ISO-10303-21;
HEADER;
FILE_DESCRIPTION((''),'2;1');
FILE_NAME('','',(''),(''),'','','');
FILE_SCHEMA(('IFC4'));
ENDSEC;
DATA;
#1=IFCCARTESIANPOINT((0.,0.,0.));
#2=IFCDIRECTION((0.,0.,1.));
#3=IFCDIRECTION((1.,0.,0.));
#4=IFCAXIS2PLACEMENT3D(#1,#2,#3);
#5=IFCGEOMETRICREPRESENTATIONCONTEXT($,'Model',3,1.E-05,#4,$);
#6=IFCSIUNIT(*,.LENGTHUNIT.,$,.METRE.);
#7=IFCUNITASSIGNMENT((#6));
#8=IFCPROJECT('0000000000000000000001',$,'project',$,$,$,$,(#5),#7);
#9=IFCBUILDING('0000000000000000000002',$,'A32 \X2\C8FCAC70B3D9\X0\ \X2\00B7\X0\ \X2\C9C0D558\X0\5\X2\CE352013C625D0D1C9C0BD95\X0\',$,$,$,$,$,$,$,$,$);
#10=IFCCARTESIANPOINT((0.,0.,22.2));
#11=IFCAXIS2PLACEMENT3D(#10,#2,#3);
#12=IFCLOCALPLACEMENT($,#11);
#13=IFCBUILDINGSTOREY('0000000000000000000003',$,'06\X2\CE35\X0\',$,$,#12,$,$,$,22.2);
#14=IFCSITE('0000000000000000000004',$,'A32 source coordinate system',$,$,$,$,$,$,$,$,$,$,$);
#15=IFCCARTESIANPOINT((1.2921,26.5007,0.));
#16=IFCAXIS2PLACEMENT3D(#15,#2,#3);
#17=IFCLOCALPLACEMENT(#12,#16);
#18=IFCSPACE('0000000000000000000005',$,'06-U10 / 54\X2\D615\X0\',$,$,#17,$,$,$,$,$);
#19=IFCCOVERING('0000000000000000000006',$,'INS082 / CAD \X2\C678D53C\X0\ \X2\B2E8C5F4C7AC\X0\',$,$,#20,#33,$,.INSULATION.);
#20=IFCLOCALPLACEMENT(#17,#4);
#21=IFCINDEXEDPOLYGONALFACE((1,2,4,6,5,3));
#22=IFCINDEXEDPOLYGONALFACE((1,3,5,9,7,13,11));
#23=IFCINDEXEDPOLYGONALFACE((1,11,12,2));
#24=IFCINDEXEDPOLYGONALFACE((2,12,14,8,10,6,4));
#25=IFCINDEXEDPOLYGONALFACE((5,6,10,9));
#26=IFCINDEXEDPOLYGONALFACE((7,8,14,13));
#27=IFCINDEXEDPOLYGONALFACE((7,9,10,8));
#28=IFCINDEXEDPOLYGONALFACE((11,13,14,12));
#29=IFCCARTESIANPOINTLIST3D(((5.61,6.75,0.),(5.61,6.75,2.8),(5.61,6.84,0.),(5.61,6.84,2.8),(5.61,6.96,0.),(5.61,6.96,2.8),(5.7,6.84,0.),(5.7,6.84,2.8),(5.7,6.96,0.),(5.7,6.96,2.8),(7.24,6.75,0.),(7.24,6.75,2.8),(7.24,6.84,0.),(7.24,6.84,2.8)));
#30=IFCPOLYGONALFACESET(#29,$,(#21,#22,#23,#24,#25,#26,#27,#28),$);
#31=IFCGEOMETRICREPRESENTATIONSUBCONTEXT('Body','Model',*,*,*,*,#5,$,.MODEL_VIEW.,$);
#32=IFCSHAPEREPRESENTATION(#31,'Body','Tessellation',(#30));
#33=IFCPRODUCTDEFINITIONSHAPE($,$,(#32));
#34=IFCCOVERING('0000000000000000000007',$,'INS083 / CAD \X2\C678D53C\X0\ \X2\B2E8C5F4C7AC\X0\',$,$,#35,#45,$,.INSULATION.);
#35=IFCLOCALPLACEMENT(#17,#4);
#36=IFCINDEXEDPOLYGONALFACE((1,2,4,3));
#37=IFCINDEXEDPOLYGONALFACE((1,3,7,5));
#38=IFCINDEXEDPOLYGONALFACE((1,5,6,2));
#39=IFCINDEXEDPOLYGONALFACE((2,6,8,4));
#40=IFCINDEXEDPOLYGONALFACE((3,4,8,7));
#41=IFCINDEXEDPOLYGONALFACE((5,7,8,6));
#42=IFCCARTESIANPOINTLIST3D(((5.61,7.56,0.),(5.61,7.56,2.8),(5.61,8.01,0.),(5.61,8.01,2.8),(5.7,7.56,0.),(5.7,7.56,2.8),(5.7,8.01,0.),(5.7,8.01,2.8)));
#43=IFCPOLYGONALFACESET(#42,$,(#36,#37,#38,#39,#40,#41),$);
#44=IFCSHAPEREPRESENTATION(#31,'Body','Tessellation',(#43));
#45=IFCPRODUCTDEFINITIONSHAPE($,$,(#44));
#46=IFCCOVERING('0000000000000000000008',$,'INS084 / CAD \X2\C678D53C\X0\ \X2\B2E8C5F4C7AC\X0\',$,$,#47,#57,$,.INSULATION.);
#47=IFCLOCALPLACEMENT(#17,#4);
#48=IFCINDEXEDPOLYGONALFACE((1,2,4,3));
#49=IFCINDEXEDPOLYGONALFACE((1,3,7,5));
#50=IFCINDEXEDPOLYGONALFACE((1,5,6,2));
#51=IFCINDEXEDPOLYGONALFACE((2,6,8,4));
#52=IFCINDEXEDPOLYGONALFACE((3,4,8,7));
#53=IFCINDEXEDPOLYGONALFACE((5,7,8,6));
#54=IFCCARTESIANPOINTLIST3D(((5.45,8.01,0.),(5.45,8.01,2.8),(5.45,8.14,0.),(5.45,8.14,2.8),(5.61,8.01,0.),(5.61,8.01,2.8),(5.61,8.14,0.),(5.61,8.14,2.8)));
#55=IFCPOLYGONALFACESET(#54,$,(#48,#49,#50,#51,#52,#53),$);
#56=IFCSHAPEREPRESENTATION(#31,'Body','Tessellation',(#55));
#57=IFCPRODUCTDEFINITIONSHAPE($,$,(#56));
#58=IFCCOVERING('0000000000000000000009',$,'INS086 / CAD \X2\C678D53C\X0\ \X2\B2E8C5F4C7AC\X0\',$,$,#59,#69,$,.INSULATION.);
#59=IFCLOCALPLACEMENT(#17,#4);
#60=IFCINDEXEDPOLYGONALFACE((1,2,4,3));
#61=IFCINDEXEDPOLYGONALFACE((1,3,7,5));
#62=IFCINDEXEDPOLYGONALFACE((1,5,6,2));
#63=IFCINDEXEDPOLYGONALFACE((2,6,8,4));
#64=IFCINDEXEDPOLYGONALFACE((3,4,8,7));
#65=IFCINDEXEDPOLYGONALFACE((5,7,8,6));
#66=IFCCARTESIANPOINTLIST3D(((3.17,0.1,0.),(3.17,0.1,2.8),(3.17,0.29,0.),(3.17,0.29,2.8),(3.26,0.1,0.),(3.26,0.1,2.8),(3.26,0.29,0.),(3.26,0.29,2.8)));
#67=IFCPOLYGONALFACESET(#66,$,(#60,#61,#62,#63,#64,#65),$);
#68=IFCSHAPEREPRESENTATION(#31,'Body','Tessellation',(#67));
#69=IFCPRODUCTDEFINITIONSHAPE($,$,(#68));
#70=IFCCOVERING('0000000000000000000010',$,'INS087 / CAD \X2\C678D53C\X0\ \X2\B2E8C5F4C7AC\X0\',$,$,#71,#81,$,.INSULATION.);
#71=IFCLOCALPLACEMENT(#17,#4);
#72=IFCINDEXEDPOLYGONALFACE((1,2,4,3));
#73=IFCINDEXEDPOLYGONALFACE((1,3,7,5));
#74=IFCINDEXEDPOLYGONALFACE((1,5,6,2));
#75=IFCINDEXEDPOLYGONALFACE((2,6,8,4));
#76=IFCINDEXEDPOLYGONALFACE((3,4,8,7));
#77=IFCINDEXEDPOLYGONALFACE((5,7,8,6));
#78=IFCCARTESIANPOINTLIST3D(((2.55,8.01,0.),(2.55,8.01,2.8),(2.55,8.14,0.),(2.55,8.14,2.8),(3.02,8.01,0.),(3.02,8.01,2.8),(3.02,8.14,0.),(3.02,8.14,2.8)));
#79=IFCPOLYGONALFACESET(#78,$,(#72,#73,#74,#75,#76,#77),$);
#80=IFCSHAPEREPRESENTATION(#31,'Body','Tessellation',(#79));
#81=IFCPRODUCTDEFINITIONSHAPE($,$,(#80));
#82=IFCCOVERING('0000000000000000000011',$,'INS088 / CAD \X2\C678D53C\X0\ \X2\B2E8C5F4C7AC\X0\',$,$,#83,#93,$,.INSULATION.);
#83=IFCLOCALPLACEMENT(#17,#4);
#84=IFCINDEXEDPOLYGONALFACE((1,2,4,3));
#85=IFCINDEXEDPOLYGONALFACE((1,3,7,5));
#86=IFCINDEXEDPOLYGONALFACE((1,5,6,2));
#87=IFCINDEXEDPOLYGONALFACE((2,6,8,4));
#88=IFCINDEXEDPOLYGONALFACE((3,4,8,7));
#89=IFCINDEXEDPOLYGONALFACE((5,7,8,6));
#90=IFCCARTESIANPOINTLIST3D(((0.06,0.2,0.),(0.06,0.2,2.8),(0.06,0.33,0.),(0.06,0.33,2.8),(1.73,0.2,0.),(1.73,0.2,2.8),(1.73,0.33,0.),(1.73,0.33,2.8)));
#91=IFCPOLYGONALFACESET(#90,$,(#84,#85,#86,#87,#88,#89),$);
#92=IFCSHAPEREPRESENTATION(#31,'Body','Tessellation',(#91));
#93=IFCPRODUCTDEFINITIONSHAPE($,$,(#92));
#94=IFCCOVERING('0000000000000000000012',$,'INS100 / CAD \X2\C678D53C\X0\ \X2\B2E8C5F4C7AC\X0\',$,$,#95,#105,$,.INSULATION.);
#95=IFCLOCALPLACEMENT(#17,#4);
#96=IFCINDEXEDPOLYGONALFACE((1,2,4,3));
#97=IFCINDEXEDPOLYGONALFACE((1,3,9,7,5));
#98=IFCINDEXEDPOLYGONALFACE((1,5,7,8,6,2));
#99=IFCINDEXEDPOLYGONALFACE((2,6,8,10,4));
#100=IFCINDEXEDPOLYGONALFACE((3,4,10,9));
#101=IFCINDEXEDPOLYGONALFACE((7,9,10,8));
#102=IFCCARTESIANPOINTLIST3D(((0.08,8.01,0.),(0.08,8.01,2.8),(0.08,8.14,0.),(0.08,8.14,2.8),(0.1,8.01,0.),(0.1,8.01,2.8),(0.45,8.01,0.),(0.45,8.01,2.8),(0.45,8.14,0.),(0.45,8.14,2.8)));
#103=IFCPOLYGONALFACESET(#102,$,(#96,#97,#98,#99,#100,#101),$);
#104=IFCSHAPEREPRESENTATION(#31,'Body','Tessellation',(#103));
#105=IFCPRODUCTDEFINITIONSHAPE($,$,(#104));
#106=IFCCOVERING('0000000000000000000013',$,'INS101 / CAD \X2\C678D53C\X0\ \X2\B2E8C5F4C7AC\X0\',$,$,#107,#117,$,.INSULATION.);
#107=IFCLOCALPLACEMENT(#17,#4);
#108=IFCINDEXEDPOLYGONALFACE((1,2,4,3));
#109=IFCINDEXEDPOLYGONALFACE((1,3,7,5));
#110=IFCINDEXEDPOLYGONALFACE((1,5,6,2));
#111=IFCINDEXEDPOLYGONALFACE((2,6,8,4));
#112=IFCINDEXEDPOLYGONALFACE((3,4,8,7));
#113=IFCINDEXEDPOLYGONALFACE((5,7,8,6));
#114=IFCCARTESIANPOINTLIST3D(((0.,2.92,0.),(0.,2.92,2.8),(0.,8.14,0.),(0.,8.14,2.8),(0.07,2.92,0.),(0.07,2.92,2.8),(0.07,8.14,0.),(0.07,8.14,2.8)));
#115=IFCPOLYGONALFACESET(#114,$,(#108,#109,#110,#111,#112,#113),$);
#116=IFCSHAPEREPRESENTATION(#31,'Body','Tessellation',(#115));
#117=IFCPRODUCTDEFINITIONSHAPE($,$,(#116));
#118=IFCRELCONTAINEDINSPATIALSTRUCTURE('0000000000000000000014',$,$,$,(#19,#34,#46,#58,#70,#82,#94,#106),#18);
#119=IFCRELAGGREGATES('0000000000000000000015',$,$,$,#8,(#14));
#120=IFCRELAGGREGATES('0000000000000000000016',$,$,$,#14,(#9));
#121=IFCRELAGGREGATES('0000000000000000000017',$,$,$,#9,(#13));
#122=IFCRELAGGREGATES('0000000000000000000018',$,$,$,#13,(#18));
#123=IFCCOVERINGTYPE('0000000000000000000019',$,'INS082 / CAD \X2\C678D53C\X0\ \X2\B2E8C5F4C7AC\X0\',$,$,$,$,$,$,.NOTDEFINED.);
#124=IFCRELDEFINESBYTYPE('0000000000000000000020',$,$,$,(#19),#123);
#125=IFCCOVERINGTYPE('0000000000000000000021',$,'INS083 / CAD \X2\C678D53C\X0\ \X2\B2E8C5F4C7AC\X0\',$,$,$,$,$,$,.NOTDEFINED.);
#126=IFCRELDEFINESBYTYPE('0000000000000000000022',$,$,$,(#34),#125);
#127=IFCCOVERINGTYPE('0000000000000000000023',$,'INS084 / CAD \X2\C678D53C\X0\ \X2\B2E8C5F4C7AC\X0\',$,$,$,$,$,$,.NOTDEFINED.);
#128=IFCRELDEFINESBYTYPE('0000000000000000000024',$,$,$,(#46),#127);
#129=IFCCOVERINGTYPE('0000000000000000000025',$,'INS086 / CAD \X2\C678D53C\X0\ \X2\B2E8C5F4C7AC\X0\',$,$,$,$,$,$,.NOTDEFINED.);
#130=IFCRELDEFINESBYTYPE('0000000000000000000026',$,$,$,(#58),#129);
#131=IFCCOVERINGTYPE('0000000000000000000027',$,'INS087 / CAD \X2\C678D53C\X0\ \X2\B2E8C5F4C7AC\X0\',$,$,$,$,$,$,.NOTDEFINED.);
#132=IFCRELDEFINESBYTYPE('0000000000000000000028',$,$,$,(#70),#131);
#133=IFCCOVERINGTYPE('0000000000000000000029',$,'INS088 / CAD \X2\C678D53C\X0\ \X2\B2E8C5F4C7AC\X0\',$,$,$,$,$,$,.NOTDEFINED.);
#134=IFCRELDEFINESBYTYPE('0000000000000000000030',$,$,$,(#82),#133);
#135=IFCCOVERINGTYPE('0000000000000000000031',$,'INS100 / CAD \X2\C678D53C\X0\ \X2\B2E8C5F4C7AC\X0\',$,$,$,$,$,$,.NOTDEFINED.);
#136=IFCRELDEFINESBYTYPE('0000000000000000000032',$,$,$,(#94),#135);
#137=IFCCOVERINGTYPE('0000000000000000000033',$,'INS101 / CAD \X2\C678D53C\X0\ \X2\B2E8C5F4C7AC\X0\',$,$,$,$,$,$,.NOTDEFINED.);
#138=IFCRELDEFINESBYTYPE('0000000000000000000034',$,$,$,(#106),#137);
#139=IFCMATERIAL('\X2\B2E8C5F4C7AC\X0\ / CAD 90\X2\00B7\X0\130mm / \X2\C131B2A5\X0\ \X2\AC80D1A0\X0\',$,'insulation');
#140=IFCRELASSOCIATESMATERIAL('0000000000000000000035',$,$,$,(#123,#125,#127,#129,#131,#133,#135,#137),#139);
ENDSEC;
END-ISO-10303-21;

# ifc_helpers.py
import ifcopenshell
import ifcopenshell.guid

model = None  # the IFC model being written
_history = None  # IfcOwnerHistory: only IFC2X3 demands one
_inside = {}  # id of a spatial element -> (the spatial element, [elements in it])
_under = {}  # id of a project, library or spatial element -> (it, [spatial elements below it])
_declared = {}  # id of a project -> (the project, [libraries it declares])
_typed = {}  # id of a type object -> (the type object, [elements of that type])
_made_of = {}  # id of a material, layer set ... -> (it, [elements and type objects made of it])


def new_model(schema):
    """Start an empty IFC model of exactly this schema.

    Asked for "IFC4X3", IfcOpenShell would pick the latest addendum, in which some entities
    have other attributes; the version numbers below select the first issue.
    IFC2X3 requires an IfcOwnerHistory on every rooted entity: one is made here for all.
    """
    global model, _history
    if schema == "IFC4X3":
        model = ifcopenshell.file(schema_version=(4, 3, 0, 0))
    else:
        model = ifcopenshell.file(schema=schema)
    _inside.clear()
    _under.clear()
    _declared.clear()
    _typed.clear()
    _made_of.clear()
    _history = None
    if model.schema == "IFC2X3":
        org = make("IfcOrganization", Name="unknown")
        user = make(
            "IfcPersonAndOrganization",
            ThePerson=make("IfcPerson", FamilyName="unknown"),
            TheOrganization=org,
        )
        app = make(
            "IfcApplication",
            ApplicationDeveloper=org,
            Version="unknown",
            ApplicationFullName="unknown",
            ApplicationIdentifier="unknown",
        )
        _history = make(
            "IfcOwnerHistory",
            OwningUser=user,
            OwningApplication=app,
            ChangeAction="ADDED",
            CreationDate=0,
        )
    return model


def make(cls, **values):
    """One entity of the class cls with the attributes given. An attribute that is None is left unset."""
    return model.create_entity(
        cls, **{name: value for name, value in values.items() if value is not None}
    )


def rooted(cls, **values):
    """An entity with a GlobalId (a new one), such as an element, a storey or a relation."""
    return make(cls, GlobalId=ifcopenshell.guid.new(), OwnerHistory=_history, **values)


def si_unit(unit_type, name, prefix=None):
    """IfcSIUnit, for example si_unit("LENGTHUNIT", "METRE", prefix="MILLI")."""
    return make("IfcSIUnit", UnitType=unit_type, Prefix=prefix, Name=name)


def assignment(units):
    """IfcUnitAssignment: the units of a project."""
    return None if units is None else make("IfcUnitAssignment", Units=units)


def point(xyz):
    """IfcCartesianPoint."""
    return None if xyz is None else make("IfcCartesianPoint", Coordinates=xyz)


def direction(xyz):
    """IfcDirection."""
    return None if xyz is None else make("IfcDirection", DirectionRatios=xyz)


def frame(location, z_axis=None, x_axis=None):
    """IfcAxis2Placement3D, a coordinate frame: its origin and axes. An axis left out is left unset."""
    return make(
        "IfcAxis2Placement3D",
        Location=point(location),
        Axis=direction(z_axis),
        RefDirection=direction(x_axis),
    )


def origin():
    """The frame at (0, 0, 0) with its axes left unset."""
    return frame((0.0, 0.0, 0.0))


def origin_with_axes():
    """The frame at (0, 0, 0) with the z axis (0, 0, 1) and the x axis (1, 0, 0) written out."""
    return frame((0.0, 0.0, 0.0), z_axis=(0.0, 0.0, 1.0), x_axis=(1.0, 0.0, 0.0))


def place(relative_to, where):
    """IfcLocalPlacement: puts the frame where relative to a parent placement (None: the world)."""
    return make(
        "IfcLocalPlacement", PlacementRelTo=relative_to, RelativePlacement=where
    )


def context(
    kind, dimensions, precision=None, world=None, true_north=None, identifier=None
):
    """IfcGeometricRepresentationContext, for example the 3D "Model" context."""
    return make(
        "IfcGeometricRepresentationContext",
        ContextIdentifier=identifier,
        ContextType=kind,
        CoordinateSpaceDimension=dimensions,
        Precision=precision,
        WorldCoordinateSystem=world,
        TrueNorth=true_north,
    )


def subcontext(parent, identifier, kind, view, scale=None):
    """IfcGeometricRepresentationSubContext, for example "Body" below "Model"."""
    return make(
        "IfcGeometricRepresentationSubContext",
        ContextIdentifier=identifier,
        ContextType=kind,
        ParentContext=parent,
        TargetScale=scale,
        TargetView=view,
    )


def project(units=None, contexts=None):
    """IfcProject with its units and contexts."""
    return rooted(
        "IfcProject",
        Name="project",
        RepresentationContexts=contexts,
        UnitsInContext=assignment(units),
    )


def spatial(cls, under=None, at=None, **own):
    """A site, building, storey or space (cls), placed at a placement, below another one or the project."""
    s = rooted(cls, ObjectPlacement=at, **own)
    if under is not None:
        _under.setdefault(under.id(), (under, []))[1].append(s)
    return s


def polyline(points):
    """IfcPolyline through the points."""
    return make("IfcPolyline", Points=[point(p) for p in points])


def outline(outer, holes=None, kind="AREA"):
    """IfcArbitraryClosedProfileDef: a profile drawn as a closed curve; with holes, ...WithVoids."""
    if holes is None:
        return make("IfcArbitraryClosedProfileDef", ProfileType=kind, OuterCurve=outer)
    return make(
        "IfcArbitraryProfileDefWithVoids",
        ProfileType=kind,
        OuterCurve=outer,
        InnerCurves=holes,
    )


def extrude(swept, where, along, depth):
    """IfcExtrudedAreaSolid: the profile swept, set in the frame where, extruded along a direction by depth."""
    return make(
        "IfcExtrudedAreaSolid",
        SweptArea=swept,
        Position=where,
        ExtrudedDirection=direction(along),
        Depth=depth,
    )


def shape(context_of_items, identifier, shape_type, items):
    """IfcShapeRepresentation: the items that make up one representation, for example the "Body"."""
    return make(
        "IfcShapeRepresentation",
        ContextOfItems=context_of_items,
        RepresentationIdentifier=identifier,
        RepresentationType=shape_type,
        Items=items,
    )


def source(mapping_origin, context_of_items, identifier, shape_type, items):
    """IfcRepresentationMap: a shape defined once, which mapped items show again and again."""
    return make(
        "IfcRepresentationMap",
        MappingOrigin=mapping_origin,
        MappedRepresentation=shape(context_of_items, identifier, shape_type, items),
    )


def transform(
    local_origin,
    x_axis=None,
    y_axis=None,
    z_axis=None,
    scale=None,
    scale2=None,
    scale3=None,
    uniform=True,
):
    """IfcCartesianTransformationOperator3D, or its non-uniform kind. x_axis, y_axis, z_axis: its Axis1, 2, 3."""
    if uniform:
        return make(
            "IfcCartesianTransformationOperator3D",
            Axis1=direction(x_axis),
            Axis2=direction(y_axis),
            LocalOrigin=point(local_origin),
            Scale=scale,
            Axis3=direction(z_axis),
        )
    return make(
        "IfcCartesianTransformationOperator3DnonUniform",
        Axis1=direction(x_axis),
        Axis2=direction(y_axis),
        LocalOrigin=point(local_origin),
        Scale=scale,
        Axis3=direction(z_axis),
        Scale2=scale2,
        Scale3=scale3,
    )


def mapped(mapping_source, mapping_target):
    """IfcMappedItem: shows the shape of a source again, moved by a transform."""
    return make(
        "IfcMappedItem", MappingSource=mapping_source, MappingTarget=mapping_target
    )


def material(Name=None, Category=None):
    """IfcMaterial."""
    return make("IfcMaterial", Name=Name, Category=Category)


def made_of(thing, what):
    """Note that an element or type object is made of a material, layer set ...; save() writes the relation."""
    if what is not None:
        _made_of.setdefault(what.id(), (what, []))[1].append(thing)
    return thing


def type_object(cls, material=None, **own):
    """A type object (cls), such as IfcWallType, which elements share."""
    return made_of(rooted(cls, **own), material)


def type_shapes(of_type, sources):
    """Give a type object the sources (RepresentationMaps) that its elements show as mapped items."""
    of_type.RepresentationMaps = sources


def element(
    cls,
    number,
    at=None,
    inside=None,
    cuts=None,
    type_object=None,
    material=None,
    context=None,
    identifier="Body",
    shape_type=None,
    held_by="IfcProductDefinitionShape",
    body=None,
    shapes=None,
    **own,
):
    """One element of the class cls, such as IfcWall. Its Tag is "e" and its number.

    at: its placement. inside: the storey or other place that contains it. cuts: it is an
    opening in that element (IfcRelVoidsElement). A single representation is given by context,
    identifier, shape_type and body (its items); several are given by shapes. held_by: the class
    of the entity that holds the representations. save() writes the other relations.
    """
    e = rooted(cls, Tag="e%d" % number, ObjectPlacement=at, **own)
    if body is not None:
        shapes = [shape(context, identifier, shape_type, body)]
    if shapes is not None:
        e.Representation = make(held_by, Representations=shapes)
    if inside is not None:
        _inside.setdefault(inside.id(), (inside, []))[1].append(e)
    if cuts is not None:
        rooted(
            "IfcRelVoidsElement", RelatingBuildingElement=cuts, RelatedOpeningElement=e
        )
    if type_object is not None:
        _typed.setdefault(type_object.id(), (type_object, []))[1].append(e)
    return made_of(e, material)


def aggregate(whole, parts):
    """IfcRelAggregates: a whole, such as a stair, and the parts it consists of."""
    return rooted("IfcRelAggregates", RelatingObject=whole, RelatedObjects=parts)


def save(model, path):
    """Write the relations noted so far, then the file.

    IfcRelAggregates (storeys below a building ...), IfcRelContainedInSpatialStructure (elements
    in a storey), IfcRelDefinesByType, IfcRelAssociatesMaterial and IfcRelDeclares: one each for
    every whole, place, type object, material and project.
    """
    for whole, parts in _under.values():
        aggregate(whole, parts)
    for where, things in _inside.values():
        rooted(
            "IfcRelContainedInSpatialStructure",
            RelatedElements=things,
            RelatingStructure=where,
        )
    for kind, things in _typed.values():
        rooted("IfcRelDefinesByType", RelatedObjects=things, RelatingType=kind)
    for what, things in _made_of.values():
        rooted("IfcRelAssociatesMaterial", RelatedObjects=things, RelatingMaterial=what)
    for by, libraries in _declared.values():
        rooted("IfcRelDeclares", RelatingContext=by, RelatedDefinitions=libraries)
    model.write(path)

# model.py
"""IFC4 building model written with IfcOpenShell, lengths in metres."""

from ifc_helpers import new_model, si_unit, frame, origin, origin_with_axes, place, context, subcontext, project, spatial, polyline, outline, extrude, source, transform, mapped, material, type_object, type_shapes, element, save


model = new_model("IFC4")

# Units and contexts
model_context = context("Model", 3, precision=1e-05, world=origin_with_axes())
body_context = subcontext(model_context, "Body", "Model", "MODEL_VIEW")
ifc_project = project(units=[si_unit("LENGTHUNIT", "METRE")], contexts=[model_context])

# Site, building, storey, space
storey_placement = place(None, frame((0.0, 0.0, 22.2), z_axis=(0.0, 0.0, 1.0), x_axis=(1.0, 0.0, 0.0)))
space_placement = place(storey_placement, frame((1.2921, 26.5007, 0.0), z_axis=(0.0, 0.0, 1.0), x_axis=(1.0, 0.0, 0.0)))
site = spatial("IfcSite", under=ifc_project, Name="A32 source coordinate system")
building = spatial("IfcBuilding", under=site, Name="A32 주거동 · 지하5층–옥탑지붕")
storey = spatial("IfcBuildingStorey", under=building, at=storey_placement, Name="06층", Elevation=22.2)
space = spatial("IfcSpace", under=storey, at=space_placement, Name="06-U10 / 54형")

# Coverings
ifc_material = material(Name="단열재 / CAD 90·130mm / 성능 검토", Category="insulation")
covering_type_1 = type_object("IfcCoveringType", Name="INS082 / CAD 외피 단열재", PredefinedType="NOTDEFINED", material=ifc_material)
shared_shape_1 = source(origin(), body_context, "Body", "SweptSolid", [
    extrude(outline(polyline([(5.61, 6.84), (5.61, 6.96), (5.7, 6.96), (5.7, 6.84), (7.24, 6.84), (7.24, 6.75), (5.61, 6.75), (5.61, 6.84)])), origin(), (0.0, 0.0, 1.0), 2.8),
])
type_shapes(covering_type_1, [shared_shape_1])
covering_1_placement = place(space_placement, origin_with_axes())
element("IfcCovering", 1, at=covering_1_placement, inside=space, type_object=covering_type_1, Name="INS082 / CAD 외피 단열재", PredefinedType="INSULATION", context=body_context, shape_type="MappedRepresentation", body=[
    mapped(shared_shape_1, transform((0.0, 0.0, 0.0), scale=1.0)),
])
covering_type_2 = type_object("IfcCoveringType", Name="INS083 / CAD 외피 단열재", PredefinedType="NOTDEFINED", material=ifc_material)
shared_shape_2 = source(origin(), body_context, "Body", "SweptSolid", [
    extrude(outline(polyline([(5.61, 8.01), (5.7, 8.01), (5.7, 7.56), (5.61, 7.56), (5.61, 8.01)])), origin(), (0.0, 0.0, 1.0), 2.8),
])
type_shapes(covering_type_2, [shared_shape_2])
covering_2_placement = place(space_placement, origin_with_axes())
element("IfcCovering", 2, at=covering_2_placement, inside=space, type_object=covering_type_2, Name="INS083 / CAD 외피 단열재", PredefinedType="INSULATION", context=body_context, shape_type="MappedRepresentation", body=[
    mapped(shared_shape_2, transform((0.0, 0.0, 0.0), scale=1.0)),
])
covering_type_3 = type_object("IfcCoveringType", Name="INS084 / CAD 외피 단열재", PredefinedType="NOTDEFINED", material=ifc_material)
shared_shape_3 = source(origin(), body_context, "Body", "SweptSolid", [
    extrude(outline(polyline([(5.45, 8.01), (5.45, 8.14), (5.61, 8.14), (5.61, 8.01), (5.45, 8.01)])), origin(), (0.0, 0.0, 1.0), 2.8),
])
type_shapes(covering_type_3, [shared_shape_3])
covering_3_placement = place(space_placement, origin_with_axes())
element("IfcCovering", 3, at=covering_3_placement, inside=space, type_object=covering_type_3, Name="INS084 / CAD 외피 단열재", PredefinedType="INSULATION", context=body_context, shape_type="MappedRepresentation", body=[
    mapped(shared_shape_3, transform((0.0, 0.0, 0.0), scale=1.0)),
])
covering_type_4 = type_object("IfcCoveringType", Name="INS086 / CAD 외피 단열재", PredefinedType="NOTDEFINED", material=ifc_material)
shared_shape_4 = source(origin(), body_context, "Body", "SweptSolid", [
    extrude(outline(polyline([(3.17, 0.1), (3.17, 0.29), (3.26, 0.29), (3.26, 0.1), (3.17, 0.1)])), origin(), (0.0, 0.0, 1.0), 2.8),
])
type_shapes(covering_type_4, [shared_shape_4])
covering_4_placement = place(space_placement, origin_with_axes())
element("IfcCovering", 4, at=covering_4_placement, inside=space, type_object=covering_type_4, Name="INS086 / CAD 외피 단열재", PredefinedType="INSULATION", context=body_context, shape_type="MappedRepresentation", body=[
    mapped(shared_shape_4, transform((0.0, 0.0, 0.0), scale=1.0)),
])
covering_type_5 = type_object("IfcCoveringType", Name="INS087 / CAD 외피 단열재", PredefinedType="NOTDEFINED", material=ifc_material)
shared_shape_5 = source(origin(), body_context, "Body", "SweptSolid", [
    extrude(outline(polyline([(2.55, 8.14), (3.02, 8.14), (3.02, 8.01), (2.55, 8.01), (2.55, 8.14)])), origin(), (0.0, 0.0, 1.0), 2.8),
])
type_shapes(covering_type_5, [shared_shape_5])
covering_5_placement = place(space_placement, origin_with_axes())
element("IfcCovering", 5, at=covering_5_placement, inside=space, type_object=covering_type_5, Name="INS087 / CAD 외피 단열재", PredefinedType="INSULATION", context=body_context, shape_type="MappedRepresentation", body=[
    mapped(shared_shape_5, transform((0.0, 0.0, 0.0), scale=1.0)),
])
covering_type_6 = type_object("IfcCoveringType", Name="INS088 / CAD 외피 단열재", PredefinedType="NOTDEFINED", material=ifc_material)
shared_shape_6 = source(origin(), body_context, "Body", "SweptSolid", [
    extrude(outline(polyline([(0.06, 0.33), (1.73, 0.33), (1.73, 0.2), (0.06, 0.2), (0.06, 0.33)])), origin(), (0.0, 0.0, 1.0), 2.8),
])
type_shapes(covering_type_6, [shared_shape_6])
covering_6_placement = place(space_placement, origin_with_axes())
element("IfcCovering", 6, at=covering_6_placement, inside=space, type_object=covering_type_6, Name="INS088 / CAD 외피 단열재", PredefinedType="INSULATION", context=body_context, shape_type="MappedRepresentation", body=[
    mapped(shared_shape_6, transform((0.0, 0.0, 0.0), scale=1.0)),
])
covering_type_7 = type_object("IfcCoveringType", Name="INS100 / CAD 외피 단열재", PredefinedType="NOTDEFINED", material=ifc_material)
shared_shape_7 = source(origin(), body_context, "Body", "SweptSolid", [
    extrude(outline(polyline([(0.08, 8.01), (0.08, 8.14), (0.45, 8.14), (0.45, 8.01), (0.1, 8.01), (0.08, 8.01)])), origin(), (0.0, 0.0, 1.0), 2.8),
])
type_shapes(covering_type_7, [shared_shape_7])
covering_7_placement = place(space_placement, origin_with_axes())
element("IfcCovering", 7, at=covering_7_placement, inside=space, type_object=covering_type_7, Name="INS100 / CAD 외피 단열재", PredefinedType="INSULATION", context=body_context, shape_type="MappedRepresentation", body=[
    mapped(shared_shape_7, transform((0.0, 0.0, 0.0), scale=1.0)),
])
covering_type_8 = type_object("IfcCoveringType", Name="INS101 / CAD 외피 단열재", PredefinedType="NOTDEFINED", material=ifc_material)
shared_shape_8 = source(origin(), body_context, "Body", "SweptSolid", [
    extrude(outline(polyline([(0.0, 2.92), (0.0, 8.14), (0.07, 8.14), (0.07, 2.92), (0.0, 2.92)])), origin(), (0.0, 0.0, 1.0), 2.8),
])
type_shapes(covering_type_8, [shared_shape_8])
covering_8_placement = place(space_placement, origin_with_axes())
element("IfcCovering", 8, at=covering_8_placement, inside=space, type_object=covering_type_8, Name="INS101 / CAD 외피 단열재", PredefinedType="INSULATION", context=body_context, shape_type="MappedRepresentation", body=[
    mapped(shared_shape_8, transform((0.0, 0.0, 0.0), scale=1.0)),
])

save(model, "model.ifc")
